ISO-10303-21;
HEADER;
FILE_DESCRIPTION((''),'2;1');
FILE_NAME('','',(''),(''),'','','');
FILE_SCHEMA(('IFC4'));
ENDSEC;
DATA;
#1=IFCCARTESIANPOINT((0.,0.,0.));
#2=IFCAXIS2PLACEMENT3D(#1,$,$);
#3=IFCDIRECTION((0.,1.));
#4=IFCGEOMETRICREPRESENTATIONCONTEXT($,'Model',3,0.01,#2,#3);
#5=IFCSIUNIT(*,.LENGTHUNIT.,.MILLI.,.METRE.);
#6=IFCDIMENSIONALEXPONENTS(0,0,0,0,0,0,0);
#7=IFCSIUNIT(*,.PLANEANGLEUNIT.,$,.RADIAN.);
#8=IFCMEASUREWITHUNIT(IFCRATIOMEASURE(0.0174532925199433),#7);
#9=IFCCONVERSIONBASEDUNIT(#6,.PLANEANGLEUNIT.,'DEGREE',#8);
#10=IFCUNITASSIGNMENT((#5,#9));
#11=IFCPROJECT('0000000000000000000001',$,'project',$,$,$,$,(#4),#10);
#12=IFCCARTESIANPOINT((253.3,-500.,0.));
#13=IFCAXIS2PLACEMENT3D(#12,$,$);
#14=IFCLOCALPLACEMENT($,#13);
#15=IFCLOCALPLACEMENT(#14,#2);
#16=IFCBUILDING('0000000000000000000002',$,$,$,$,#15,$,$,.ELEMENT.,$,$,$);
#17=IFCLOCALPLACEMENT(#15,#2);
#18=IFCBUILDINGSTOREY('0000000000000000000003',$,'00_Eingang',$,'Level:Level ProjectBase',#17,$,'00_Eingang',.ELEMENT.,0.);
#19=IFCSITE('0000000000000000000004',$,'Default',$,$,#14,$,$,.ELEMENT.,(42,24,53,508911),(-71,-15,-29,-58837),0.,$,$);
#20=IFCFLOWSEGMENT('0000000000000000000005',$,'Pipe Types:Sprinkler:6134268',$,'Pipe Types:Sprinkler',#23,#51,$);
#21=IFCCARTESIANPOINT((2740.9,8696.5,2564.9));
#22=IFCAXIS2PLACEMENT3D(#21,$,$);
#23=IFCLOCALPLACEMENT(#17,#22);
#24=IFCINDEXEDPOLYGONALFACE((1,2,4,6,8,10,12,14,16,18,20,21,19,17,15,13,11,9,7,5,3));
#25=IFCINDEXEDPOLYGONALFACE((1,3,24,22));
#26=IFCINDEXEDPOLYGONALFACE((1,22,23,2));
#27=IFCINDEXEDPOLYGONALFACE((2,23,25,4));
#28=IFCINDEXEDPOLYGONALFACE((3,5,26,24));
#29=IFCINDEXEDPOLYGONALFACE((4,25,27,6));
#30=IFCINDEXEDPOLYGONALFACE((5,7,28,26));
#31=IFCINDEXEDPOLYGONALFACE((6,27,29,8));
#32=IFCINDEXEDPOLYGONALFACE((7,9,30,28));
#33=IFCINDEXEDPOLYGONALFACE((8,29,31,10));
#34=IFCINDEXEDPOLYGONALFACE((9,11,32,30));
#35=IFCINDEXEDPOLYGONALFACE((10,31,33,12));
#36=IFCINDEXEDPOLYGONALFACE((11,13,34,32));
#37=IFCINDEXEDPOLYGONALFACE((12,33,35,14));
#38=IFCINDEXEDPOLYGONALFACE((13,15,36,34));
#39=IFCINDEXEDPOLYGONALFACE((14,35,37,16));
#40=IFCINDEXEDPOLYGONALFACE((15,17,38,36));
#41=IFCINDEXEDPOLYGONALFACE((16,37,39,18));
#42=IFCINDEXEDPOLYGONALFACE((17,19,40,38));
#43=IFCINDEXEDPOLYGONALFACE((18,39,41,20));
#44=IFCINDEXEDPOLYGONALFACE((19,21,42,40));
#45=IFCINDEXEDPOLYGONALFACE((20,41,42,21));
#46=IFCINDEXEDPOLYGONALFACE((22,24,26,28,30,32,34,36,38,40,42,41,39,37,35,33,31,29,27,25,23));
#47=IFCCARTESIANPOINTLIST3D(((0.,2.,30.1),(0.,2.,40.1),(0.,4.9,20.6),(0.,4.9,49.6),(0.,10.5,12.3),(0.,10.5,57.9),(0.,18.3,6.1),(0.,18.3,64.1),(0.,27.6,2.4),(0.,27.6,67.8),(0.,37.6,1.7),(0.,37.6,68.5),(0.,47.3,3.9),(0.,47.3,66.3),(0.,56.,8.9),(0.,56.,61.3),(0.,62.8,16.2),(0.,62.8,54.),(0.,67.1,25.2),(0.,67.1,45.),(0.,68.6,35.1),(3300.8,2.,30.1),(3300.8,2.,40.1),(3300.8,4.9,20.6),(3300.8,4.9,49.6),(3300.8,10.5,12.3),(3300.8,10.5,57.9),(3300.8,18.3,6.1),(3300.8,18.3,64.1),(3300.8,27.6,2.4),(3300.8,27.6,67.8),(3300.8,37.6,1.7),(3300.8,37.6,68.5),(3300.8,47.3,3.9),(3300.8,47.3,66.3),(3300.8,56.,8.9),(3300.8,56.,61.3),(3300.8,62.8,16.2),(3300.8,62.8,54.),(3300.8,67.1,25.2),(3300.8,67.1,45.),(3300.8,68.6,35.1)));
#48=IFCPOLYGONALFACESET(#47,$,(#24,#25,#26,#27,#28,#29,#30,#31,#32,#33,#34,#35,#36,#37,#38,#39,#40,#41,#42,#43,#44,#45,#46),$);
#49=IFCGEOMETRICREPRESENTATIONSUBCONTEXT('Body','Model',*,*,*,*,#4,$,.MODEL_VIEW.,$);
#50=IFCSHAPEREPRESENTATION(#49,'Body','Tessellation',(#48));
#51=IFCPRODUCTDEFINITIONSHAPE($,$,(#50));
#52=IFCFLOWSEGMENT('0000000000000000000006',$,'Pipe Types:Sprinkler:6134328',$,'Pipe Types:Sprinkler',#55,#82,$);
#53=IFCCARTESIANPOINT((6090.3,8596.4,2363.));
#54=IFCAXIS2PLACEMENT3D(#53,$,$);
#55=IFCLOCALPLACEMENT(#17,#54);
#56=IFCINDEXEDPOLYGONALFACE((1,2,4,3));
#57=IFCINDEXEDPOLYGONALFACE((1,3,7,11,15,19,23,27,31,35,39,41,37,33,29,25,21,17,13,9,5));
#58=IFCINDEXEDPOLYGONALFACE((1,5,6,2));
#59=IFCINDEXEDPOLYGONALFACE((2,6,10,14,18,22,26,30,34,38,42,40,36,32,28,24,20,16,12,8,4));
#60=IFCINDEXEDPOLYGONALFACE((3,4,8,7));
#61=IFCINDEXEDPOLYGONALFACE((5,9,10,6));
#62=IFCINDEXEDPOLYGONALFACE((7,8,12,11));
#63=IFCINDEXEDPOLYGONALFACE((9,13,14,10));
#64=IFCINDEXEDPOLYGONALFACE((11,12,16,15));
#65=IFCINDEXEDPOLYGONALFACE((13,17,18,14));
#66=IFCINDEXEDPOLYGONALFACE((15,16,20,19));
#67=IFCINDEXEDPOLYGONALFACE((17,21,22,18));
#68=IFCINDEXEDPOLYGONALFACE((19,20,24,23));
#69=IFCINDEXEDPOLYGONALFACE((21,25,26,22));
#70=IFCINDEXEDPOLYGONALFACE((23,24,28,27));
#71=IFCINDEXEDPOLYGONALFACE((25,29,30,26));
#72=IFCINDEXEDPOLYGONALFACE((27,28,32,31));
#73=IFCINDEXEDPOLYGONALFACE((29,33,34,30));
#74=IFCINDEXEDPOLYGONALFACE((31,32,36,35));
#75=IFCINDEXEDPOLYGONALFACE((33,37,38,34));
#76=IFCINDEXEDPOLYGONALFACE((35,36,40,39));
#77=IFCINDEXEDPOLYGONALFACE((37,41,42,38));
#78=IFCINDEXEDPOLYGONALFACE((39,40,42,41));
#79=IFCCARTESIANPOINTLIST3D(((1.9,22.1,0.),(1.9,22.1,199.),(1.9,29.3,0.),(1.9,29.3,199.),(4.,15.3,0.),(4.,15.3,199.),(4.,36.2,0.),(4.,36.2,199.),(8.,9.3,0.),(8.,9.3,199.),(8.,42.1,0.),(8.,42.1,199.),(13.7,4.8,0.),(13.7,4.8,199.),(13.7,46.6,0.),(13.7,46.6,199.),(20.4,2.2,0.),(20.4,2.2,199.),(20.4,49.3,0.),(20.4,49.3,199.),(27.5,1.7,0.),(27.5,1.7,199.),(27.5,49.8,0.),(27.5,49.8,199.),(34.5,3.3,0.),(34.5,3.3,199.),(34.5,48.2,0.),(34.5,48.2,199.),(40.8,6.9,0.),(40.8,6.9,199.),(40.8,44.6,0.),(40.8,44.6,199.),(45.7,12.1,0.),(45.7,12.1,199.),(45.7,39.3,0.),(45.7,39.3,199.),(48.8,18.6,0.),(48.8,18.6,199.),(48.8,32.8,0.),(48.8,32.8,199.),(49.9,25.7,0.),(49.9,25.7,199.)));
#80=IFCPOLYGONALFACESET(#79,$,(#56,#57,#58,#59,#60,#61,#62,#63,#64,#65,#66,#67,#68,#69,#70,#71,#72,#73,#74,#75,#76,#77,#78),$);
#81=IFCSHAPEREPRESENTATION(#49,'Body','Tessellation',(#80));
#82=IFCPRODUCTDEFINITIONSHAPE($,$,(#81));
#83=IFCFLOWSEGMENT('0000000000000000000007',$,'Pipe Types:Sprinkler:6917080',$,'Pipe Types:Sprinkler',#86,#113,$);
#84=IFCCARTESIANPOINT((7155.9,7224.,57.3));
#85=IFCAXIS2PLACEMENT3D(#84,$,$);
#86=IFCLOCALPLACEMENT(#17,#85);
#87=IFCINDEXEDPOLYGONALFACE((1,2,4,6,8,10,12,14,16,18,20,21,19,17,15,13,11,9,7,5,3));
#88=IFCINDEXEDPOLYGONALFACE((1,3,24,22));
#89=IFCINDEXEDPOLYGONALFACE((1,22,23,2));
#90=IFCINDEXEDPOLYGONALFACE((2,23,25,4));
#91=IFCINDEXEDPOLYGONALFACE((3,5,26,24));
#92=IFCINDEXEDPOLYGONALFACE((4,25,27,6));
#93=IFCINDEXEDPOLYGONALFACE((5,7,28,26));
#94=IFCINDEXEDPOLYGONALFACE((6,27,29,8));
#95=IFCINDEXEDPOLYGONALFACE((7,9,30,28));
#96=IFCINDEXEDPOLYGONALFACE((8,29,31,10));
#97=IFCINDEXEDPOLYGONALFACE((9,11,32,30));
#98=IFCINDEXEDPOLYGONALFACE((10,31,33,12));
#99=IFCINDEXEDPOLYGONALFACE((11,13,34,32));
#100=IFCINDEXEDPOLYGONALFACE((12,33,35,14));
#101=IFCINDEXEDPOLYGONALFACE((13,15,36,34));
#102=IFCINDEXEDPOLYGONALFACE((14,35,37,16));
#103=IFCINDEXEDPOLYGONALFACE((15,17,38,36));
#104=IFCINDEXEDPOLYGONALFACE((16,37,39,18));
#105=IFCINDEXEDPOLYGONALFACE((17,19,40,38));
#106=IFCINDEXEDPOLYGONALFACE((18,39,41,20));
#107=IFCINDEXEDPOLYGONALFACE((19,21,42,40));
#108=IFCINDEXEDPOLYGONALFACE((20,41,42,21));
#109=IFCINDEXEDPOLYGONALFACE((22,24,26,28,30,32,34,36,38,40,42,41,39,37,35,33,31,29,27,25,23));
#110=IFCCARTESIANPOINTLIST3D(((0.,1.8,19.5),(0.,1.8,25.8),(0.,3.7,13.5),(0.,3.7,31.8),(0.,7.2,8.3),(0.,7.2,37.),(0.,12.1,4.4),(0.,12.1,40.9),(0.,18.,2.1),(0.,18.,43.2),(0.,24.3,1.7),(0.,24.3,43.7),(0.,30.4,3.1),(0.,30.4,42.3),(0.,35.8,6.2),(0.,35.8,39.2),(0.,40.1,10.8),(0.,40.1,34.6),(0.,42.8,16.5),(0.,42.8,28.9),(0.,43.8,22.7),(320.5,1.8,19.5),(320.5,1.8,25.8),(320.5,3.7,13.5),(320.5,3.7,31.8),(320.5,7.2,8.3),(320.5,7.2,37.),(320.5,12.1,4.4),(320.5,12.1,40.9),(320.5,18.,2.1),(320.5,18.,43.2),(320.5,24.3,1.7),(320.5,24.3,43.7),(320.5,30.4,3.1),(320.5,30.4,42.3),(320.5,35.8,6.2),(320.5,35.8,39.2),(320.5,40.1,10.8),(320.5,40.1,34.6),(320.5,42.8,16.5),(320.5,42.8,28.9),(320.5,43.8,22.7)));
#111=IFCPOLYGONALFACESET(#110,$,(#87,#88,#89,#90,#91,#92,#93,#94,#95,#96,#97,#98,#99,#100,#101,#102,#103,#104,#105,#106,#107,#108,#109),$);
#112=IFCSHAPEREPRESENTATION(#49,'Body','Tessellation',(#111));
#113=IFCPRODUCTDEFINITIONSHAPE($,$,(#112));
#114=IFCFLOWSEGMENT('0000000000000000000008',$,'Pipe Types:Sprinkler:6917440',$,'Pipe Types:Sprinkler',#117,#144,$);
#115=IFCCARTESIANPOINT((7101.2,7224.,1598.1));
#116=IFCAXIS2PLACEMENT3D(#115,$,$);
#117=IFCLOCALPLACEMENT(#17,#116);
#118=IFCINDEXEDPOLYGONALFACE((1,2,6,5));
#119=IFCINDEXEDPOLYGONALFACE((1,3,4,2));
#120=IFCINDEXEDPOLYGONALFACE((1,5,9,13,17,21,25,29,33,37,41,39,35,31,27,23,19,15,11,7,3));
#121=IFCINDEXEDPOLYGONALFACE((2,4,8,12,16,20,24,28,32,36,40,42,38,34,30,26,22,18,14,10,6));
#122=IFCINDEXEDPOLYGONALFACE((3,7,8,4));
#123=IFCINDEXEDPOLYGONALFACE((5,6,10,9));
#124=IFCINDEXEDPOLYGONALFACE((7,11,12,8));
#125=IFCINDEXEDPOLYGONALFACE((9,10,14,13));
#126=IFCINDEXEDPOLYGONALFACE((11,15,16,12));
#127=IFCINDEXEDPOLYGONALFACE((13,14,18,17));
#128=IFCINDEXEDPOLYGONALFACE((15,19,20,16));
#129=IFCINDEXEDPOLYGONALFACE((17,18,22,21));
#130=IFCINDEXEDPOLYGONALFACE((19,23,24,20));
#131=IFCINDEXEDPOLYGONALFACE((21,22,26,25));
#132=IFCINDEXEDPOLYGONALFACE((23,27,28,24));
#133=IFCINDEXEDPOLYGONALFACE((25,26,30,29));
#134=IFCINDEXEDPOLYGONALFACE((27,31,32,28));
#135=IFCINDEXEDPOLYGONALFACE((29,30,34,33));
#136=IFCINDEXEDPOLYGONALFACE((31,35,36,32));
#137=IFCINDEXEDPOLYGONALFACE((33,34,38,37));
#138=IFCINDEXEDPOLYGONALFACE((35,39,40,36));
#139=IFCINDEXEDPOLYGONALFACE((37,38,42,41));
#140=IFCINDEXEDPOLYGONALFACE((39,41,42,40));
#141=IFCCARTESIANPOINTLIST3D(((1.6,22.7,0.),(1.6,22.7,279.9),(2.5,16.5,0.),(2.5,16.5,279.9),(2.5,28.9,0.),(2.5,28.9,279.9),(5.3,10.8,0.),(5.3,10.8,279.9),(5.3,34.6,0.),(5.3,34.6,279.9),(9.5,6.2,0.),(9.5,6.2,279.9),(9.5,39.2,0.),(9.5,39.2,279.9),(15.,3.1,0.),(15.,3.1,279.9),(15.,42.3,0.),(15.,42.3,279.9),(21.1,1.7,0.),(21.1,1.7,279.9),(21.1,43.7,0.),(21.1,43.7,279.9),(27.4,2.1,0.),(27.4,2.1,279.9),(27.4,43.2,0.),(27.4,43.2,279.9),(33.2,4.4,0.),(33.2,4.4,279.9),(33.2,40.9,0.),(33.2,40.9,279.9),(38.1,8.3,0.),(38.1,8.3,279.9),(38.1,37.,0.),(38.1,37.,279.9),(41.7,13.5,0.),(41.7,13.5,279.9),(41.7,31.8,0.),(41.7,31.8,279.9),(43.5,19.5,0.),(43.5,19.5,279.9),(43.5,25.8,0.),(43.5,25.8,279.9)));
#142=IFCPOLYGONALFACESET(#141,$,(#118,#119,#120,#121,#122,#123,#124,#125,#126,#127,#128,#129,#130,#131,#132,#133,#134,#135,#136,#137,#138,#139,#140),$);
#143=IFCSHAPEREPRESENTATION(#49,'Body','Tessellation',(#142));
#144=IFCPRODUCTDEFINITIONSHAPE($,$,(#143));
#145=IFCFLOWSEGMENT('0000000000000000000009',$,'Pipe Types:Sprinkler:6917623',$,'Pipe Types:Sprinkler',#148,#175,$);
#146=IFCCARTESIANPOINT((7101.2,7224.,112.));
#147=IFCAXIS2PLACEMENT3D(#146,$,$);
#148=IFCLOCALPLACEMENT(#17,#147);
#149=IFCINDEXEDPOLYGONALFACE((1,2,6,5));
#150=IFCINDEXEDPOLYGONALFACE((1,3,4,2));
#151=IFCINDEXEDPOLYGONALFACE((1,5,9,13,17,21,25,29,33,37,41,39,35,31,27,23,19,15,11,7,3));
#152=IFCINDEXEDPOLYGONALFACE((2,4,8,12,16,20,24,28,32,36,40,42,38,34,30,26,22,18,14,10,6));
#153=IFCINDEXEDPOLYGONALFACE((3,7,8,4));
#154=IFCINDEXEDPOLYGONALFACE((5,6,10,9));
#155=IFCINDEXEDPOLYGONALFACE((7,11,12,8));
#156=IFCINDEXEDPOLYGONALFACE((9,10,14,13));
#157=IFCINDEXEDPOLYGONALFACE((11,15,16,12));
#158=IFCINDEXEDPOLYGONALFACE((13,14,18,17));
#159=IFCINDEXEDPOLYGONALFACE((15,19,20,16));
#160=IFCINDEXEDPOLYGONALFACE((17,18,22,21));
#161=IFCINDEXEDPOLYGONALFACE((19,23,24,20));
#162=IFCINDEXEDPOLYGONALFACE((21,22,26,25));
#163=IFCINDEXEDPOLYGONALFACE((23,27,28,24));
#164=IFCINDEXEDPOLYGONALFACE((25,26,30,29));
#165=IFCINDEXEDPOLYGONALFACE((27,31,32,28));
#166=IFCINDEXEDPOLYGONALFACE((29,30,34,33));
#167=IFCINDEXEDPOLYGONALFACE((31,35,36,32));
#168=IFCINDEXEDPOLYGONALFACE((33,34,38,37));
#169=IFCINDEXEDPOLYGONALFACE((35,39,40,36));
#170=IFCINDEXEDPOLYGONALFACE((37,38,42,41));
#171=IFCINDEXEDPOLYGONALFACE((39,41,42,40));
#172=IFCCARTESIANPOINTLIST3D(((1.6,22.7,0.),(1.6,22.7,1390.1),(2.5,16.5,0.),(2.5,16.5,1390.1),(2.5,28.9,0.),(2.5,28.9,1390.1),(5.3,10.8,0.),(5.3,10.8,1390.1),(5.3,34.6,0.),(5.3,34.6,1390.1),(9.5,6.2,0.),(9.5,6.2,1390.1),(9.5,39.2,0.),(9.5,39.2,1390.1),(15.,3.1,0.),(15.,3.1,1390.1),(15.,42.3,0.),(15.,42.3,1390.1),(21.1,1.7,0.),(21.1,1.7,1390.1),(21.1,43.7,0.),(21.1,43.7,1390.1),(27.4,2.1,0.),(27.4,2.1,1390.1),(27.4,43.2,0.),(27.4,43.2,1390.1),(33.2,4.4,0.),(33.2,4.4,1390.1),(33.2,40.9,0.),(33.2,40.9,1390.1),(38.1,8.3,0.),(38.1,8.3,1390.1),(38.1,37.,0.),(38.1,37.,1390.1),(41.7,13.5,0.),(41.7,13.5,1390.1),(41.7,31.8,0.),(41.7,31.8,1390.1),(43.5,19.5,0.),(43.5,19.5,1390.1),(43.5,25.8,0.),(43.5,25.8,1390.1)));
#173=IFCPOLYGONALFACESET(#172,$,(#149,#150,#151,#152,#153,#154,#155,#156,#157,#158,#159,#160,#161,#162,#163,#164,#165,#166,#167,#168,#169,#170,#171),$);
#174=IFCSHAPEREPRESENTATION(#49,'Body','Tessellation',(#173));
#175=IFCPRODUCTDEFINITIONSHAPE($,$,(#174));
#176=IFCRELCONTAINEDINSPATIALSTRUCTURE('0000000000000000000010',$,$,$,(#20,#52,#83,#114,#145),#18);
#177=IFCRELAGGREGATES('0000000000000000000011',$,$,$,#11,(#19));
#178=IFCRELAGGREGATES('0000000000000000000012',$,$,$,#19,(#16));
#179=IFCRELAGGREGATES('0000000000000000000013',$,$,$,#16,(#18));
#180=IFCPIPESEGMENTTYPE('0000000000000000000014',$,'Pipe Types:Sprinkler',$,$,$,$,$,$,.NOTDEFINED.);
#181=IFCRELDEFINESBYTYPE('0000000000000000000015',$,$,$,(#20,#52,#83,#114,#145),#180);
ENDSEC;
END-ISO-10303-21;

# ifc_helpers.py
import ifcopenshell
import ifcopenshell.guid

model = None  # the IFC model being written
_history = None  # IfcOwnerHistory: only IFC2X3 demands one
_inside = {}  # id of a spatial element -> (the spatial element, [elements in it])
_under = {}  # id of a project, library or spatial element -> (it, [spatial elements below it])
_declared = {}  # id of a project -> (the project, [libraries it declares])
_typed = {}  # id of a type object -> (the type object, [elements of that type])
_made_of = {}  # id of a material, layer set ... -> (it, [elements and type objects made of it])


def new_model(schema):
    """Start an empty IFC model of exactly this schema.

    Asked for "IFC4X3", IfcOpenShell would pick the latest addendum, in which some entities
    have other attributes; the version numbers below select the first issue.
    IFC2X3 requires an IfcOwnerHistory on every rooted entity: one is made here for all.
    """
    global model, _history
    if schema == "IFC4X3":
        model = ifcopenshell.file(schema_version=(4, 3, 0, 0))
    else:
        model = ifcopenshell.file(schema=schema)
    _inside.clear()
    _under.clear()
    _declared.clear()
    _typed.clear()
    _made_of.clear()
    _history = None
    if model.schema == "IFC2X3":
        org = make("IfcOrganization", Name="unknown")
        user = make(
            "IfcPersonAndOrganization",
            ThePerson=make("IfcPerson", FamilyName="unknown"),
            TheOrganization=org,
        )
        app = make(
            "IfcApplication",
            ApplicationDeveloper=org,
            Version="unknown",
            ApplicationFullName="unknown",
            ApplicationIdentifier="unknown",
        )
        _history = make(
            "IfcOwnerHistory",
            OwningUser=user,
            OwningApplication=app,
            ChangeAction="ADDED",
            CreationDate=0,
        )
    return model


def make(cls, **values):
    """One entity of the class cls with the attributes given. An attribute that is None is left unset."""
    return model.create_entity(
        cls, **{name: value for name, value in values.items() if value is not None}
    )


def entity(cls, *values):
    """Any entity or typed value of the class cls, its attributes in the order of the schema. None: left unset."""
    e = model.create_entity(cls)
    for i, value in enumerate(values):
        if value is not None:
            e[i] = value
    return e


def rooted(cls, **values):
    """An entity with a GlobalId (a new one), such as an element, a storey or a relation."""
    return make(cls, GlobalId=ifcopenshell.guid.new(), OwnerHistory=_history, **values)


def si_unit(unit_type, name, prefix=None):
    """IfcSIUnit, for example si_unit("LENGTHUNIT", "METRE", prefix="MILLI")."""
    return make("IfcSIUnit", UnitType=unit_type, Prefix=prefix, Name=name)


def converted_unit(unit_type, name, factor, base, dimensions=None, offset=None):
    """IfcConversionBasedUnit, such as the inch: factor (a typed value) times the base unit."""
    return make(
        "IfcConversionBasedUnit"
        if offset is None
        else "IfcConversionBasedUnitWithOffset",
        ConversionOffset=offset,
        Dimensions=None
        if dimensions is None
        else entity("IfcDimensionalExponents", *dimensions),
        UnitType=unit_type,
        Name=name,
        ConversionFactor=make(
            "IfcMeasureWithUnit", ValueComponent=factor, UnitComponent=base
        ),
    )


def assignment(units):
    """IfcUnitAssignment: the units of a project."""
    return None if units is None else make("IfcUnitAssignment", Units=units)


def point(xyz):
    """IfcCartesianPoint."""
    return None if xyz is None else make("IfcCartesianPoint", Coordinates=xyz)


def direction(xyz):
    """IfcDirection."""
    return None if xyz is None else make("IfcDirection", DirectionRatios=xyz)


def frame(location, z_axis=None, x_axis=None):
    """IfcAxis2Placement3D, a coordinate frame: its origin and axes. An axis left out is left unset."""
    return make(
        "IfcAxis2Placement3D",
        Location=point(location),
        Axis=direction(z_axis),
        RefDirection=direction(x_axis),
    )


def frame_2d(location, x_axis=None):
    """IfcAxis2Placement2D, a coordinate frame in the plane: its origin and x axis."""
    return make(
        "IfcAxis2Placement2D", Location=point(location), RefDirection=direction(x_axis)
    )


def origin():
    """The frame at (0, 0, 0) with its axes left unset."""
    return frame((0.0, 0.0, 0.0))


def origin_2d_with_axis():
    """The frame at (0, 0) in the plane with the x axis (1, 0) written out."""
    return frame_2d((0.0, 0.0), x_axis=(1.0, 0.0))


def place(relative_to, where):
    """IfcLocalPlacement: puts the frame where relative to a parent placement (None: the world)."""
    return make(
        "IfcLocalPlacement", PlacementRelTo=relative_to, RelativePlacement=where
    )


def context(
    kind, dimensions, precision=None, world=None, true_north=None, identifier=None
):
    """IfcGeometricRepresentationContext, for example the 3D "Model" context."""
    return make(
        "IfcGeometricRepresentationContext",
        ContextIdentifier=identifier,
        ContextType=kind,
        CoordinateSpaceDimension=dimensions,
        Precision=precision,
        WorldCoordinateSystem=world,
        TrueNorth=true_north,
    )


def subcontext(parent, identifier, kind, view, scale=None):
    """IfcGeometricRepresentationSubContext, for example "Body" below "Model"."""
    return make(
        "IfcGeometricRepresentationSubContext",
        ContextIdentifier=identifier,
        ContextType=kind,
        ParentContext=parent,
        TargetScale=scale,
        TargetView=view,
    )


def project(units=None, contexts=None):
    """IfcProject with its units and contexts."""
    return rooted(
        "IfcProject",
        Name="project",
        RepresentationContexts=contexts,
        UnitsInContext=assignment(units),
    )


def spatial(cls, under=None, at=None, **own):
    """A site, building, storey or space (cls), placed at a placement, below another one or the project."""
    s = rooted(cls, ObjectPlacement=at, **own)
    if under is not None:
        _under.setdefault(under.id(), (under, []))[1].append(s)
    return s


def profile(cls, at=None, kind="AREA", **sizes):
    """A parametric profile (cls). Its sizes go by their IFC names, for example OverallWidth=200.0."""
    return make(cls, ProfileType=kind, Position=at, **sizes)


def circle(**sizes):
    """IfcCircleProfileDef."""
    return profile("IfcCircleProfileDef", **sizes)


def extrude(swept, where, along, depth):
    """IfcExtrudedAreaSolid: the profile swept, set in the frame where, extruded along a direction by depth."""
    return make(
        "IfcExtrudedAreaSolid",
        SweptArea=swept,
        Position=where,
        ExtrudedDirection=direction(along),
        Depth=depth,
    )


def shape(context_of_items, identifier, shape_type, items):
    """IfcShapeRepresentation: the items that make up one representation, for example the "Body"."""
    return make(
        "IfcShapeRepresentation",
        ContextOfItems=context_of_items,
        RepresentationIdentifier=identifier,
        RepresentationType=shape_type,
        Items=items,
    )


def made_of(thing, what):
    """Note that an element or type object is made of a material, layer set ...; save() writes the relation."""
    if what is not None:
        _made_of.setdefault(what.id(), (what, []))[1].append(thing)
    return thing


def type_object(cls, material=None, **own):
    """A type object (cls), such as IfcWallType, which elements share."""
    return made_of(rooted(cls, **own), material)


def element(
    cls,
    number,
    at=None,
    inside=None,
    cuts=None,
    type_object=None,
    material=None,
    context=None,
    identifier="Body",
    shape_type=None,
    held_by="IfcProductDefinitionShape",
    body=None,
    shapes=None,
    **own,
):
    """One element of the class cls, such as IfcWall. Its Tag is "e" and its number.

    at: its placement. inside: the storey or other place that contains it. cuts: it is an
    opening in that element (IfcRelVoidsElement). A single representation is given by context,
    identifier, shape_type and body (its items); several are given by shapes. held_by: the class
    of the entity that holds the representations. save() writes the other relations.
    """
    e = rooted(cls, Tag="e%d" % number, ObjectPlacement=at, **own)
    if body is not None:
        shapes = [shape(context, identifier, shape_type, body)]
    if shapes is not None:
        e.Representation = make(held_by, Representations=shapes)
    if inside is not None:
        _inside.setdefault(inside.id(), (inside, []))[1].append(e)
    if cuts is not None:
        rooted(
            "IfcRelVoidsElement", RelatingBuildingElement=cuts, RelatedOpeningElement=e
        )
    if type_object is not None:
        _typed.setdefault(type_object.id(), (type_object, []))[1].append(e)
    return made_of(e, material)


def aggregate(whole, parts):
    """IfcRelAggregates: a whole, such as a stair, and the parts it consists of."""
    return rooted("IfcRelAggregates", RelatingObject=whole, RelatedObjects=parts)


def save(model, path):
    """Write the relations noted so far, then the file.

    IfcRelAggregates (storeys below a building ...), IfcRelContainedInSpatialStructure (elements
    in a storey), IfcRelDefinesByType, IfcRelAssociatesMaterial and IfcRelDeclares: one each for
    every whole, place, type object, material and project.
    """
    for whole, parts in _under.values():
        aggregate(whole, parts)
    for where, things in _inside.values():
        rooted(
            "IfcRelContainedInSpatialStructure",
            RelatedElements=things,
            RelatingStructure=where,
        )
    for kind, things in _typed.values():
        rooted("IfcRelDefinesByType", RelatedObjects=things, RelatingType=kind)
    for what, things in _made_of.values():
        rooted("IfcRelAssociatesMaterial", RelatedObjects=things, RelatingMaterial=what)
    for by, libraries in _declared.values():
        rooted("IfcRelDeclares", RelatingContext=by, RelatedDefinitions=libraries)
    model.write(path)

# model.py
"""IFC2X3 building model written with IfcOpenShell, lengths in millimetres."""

from ifc_helpers import new_model, entity, si_unit, converted_unit, direction, frame, frame_2d, origin, origin_2d_with_axis, place, context, subcontext, project, spatial, circle, extrude, type_object, element, save


model = new_model("IFC2X3")

# Units and contexts
model_context = context("Model", 3, precision=0.01, world=origin(), true_north=direction((0.0, 1.0)))
body_context = subcontext(model_context, "Body", "Model", "MODEL_VIEW")
ifc_project = project(units=[si_unit("LENGTHUNIT", "METRE", prefix="MILLI"), converted_unit("PLANEANGLEUNIT", "DEGREE", entity("IfcRatioMeasure", 0.0174532925199433), si_unit("PLANEANGLEUNIT", "RADIAN"), dimensions=[0, 0, 0, 0, 0, 0, 0])], contexts=[model_context])

# Site, building, storey
site_placement = place(None, frame((253.3, -500.0, 0.0)))
site = spatial("IfcSite", under=ifc_project, at=site_placement, Name="Default", CompositionType="ELEMENT", RefLatitude=(42, 24, 53, 508911), RefLongitude=(-71, -15, -29, -58837), RefElevation=0.0)
building_placement = place(site_placement, origin())
building = spatial("IfcBuilding", under=site, at=building_placement, CompositionType="ELEMENT")
storey_placement = place(building_placement, origin())
storey = spatial("IfcBuildingStorey", under=building, at=storey_placement, Name="00_Eingang", ObjectType="Level:Level ProjectBase", LongName="00_Eingang", CompositionType="ELEMENT", Elevation=0.0)

# Flow segments
pipe_segment_type = type_object("IfcPipeSegmentType", Name="Pipe Types:Sprinkler", PredefinedType="NOTDEFINED")
flow_segment_1_placement = place(storey_placement, frame((2740.9, 8696.5, 2564.9)))
element("IfcFlowSegment", 1, at=flow_segment_1_placement, inside=storey, type_object=pipe_segment_type, Name="Pipe Types:Sprinkler:6134268", ObjectType="Pipe Types:Sprinkler", context=body_context, shape_type="SweptSolid", body=[
    extrude(circle(Radius=33.5, at=origin_2d_with_axis()), frame((0.0, 35.1, 35.1), z_axis=(1.0, 0.0, 0.0), x_axis=(0.0, 1.0, 0.0)), (0.0, 0.0, 1.0), 3300.8),
])
flow_segment_2_placement = place(storey_placement, frame((6090.3, 8596.4, 2363.0)))
element("IfcFlowSegment", 2, at=flow_segment_2_placement, inside=storey, type_object=pipe_segment_type, Name="Pipe Types:Sprinkler:6134328", ObjectType="Pipe Types:Sprinkler", context=body_context, shape_type="SweptSolid", body=[
    extrude(circle(Radius=24.1, at=origin_2d_with_axis()), frame((25.7, 25.7, 0.0)), (0.0, 0.0, 1.0), 199.0),
])
flow_segment_3_placement = place(storey_placement, frame((7155.9, 7224.0, 57.3)))
element("IfcFlowSegment", 3, at=flow_segment_3_placement, inside=storey, type_object=pipe_segment_type, Name="Pipe Types:Sprinkler:6917080", ObjectType="Pipe Types:Sprinkler", context=body_context, shape_type="SweptSolid", body=[
    extrude(circle(Radius=21.1, at=frame_2d((0.0, 0.0), x_axis=(1.0, 0.0))), frame((0.0, 22.7, 22.7), z_axis=(1.0, 0.0, 0.0), x_axis=(0.0, 1.0, 0.0)), (0.0, 0.0, 1.0), 320.5),
])
flow_segment_4_placement = place(storey_placement, frame((7101.2, 7224.0, 1598.1)))
element("IfcFlowSegment", 4, at=flow_segment_4_placement, inside=storey, type_object=pipe_segment_type, Name="Pipe Types:Sprinkler:6917440", ObjectType="Pipe Types:Sprinkler", context=body_context, shape_type="SweptSolid", body=[
    extrude(circle(Radius=21.1, at=origin_2d_with_axis()), frame((22.7, 22.7, 0.0), z_axis=(0.0, 0.0, 1.0), x_axis=(-1.0, 0.0, 0.0)), (0.0, 0.0, 1.0), 279.9),
])
flow_segment_5_placement = place(storey_placement, frame((7101.2, 7224.0, 112.0)))
element("IfcFlowSegment", 5, at=flow_segment_5_placement, inside=storey, type_object=pipe_segment_type, Name="Pipe Types:Sprinkler:6917623", ObjectType="Pipe Types:Sprinkler", context=body_context, shape_type="SweptSolid", body=[
    extrude(circle(Radius=21.1, at=origin_2d_with_axis()), frame((22.7, 22.7, 0.0), z_axis=(0.0, 0.0, 1.0), x_axis=(-1.0, 0.0, 0.0)), (0.0, 0.0, 1.0), 1390.1),
])

save(model, "model.ifc")
